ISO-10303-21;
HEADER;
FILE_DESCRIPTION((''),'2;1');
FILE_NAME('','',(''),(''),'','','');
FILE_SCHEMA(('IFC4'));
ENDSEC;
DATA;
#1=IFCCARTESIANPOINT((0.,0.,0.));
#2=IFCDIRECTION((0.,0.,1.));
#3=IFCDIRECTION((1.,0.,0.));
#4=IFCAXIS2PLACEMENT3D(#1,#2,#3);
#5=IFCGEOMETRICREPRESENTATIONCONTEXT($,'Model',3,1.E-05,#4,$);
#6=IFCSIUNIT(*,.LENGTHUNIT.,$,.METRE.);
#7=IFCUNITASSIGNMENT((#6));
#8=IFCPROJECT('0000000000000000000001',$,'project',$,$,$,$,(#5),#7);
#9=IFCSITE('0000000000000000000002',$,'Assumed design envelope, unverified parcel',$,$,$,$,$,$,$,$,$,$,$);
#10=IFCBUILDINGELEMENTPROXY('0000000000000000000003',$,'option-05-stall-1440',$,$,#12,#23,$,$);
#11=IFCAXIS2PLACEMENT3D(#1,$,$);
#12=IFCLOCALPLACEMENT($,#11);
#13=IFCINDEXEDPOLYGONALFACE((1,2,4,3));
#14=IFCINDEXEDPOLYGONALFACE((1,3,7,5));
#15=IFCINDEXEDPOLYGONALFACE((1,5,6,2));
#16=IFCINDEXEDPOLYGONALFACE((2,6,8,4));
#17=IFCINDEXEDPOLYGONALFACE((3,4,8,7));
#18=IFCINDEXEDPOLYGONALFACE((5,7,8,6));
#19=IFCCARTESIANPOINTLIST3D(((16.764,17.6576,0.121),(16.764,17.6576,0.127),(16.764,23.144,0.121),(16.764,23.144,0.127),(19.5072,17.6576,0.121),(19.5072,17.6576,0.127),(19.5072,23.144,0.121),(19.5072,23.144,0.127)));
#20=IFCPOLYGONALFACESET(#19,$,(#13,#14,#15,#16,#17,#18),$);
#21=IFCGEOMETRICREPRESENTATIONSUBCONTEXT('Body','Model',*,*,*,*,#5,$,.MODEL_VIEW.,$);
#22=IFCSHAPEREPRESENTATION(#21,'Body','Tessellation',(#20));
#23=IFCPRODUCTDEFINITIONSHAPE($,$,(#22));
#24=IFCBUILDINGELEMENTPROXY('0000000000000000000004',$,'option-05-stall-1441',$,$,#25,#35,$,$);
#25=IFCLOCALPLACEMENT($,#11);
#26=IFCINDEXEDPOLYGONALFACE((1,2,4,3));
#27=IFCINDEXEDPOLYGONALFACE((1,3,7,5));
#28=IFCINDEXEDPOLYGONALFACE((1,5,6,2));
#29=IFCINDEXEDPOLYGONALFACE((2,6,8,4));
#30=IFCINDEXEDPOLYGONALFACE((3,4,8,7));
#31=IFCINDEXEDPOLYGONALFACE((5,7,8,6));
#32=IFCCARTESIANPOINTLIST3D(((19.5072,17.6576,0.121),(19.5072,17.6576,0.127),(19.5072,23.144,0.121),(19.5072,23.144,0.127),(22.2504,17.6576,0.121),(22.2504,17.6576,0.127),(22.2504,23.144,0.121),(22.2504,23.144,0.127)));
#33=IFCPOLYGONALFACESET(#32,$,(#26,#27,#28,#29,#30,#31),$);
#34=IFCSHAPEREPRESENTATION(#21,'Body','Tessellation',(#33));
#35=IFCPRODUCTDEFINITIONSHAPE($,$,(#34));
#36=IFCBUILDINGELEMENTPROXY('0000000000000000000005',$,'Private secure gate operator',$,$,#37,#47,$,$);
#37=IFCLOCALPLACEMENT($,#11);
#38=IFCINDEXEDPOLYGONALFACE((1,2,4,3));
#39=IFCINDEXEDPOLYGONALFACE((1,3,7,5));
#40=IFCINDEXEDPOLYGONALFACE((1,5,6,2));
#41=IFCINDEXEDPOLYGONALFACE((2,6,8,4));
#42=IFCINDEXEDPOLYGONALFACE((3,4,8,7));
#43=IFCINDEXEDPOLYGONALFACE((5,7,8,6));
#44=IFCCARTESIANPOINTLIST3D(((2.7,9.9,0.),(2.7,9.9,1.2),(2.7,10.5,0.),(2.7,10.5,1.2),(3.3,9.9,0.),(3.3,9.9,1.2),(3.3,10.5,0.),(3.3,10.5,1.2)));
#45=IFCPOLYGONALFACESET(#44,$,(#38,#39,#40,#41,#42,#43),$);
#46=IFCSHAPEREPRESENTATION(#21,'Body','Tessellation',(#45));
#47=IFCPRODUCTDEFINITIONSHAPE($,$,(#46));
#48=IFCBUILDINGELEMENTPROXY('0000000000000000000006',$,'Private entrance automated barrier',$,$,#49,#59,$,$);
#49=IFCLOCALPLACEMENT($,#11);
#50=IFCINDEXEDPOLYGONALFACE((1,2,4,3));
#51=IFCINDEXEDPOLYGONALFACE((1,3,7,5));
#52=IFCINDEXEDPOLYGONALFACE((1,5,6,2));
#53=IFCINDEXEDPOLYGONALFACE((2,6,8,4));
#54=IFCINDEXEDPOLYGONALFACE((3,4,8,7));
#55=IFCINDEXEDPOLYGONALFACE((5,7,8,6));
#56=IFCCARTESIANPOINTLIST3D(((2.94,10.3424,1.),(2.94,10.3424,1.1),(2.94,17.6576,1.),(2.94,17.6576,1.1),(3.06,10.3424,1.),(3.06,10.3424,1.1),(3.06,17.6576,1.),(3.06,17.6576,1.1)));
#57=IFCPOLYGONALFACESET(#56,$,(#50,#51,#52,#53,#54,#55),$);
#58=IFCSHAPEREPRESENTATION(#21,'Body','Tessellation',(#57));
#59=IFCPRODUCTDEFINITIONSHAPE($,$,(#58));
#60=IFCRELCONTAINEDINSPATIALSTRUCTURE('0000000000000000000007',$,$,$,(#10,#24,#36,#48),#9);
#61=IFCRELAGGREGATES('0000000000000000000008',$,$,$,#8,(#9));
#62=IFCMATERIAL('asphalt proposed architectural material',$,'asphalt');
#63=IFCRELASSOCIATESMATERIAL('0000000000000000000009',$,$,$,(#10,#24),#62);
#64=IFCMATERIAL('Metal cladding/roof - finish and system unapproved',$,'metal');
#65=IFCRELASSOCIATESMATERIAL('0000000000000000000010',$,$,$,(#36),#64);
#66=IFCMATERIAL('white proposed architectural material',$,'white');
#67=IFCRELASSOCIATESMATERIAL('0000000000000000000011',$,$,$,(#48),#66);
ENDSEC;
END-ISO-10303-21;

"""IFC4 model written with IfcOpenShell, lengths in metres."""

from ifc_helpers import new_model, si_unit, frame, origin_with_axes, place, context, subcontext, project, spatial, rectangle, extrude, material, element, save


model = new_model("IFC4")

# Units and contexts
model_context = context("Model", 3, precision=1e-05, world=origin_with_axes())
body_context = subcontext(model_context, "Body", "Model", "MODEL_VIEW")
ifc_project = project(units=[si_unit("LENGTHUNIT", "METRE")], contexts=[model_context])

# Site
site = spatial("IfcSite", under=ifc_project, Name="Assumed design envelope, unverified parcel")

# Building element proxies
ifc_material_1 = material(Name="asphalt proposed architectural material", Category="asphalt")
for number, where, z_axis, x_axis, name in (
    (1, (18.1356, 20.4008, 0.121), (0.0, 0.0, 1.0), (1.0, 0.0, 0.0), "option-05-stall-1440"),
    (2, (20.8788, 20.4008, 0.121), (0.0, 0.0, 1.0), (1.0, 0.0, 0.0), "option-05-stall-1441"),
):
    element("IfcBuildingElementProxy", number, at=place(None, frame(where, z_axis=z_axis, x_axis=x_axis)), inside=site, material=ifc_material_1, Name=name, context=body_context, shape_type="SweptSolid", body=[
        extrude(rectangle(XDim=2.7432, YDim=5.4864), origin_with_axes(), (0.0, 0.0, 1.0), 0.006),
    ])
ifc_material_2 = material(Name="Metal cladding/roof - finish and system unapproved", Category="metal")
proxy_1_placement = place(None, frame((3.0, 10.2, 0.0), z_axis=(0.0, 0.0, 1.0), x_axis=(1.0, 0.0, 0.0)))
element("IfcBuildingElementProxy", 3, at=proxy_1_placement, inside=site, material=ifc_material_2, Name="Private secure gate operator", context=body_context, shape_type="SweptSolid", body=[
    extrude(rectangle(XDim=0.6, YDim=0.6), origin_with_axes(), (0.0, 0.0, 1.0), 1.2),
])
ifc_material_3 = material(Name="white proposed architectural material", Category="white")
proxy_2_placement = place(None, frame((3.0, 14.0, 1.0), z_axis=(0.0, 0.0, 1.0), x_axis=(1.0, 0.0, 0.0)))
element("IfcBuildingElementProxy", 4, at=proxy_2_placement, inside=site, material=ifc_material_3, Name="Private entrance automated barrier", context=body_context, shape_type="SweptSolid", body=[
    extrude(rectangle(XDim=0.12, YDim=7.3152), origin_with_axes(), (0.0, 0.0, 1.0), 0.1),
])

save(model, "model.ifc")
